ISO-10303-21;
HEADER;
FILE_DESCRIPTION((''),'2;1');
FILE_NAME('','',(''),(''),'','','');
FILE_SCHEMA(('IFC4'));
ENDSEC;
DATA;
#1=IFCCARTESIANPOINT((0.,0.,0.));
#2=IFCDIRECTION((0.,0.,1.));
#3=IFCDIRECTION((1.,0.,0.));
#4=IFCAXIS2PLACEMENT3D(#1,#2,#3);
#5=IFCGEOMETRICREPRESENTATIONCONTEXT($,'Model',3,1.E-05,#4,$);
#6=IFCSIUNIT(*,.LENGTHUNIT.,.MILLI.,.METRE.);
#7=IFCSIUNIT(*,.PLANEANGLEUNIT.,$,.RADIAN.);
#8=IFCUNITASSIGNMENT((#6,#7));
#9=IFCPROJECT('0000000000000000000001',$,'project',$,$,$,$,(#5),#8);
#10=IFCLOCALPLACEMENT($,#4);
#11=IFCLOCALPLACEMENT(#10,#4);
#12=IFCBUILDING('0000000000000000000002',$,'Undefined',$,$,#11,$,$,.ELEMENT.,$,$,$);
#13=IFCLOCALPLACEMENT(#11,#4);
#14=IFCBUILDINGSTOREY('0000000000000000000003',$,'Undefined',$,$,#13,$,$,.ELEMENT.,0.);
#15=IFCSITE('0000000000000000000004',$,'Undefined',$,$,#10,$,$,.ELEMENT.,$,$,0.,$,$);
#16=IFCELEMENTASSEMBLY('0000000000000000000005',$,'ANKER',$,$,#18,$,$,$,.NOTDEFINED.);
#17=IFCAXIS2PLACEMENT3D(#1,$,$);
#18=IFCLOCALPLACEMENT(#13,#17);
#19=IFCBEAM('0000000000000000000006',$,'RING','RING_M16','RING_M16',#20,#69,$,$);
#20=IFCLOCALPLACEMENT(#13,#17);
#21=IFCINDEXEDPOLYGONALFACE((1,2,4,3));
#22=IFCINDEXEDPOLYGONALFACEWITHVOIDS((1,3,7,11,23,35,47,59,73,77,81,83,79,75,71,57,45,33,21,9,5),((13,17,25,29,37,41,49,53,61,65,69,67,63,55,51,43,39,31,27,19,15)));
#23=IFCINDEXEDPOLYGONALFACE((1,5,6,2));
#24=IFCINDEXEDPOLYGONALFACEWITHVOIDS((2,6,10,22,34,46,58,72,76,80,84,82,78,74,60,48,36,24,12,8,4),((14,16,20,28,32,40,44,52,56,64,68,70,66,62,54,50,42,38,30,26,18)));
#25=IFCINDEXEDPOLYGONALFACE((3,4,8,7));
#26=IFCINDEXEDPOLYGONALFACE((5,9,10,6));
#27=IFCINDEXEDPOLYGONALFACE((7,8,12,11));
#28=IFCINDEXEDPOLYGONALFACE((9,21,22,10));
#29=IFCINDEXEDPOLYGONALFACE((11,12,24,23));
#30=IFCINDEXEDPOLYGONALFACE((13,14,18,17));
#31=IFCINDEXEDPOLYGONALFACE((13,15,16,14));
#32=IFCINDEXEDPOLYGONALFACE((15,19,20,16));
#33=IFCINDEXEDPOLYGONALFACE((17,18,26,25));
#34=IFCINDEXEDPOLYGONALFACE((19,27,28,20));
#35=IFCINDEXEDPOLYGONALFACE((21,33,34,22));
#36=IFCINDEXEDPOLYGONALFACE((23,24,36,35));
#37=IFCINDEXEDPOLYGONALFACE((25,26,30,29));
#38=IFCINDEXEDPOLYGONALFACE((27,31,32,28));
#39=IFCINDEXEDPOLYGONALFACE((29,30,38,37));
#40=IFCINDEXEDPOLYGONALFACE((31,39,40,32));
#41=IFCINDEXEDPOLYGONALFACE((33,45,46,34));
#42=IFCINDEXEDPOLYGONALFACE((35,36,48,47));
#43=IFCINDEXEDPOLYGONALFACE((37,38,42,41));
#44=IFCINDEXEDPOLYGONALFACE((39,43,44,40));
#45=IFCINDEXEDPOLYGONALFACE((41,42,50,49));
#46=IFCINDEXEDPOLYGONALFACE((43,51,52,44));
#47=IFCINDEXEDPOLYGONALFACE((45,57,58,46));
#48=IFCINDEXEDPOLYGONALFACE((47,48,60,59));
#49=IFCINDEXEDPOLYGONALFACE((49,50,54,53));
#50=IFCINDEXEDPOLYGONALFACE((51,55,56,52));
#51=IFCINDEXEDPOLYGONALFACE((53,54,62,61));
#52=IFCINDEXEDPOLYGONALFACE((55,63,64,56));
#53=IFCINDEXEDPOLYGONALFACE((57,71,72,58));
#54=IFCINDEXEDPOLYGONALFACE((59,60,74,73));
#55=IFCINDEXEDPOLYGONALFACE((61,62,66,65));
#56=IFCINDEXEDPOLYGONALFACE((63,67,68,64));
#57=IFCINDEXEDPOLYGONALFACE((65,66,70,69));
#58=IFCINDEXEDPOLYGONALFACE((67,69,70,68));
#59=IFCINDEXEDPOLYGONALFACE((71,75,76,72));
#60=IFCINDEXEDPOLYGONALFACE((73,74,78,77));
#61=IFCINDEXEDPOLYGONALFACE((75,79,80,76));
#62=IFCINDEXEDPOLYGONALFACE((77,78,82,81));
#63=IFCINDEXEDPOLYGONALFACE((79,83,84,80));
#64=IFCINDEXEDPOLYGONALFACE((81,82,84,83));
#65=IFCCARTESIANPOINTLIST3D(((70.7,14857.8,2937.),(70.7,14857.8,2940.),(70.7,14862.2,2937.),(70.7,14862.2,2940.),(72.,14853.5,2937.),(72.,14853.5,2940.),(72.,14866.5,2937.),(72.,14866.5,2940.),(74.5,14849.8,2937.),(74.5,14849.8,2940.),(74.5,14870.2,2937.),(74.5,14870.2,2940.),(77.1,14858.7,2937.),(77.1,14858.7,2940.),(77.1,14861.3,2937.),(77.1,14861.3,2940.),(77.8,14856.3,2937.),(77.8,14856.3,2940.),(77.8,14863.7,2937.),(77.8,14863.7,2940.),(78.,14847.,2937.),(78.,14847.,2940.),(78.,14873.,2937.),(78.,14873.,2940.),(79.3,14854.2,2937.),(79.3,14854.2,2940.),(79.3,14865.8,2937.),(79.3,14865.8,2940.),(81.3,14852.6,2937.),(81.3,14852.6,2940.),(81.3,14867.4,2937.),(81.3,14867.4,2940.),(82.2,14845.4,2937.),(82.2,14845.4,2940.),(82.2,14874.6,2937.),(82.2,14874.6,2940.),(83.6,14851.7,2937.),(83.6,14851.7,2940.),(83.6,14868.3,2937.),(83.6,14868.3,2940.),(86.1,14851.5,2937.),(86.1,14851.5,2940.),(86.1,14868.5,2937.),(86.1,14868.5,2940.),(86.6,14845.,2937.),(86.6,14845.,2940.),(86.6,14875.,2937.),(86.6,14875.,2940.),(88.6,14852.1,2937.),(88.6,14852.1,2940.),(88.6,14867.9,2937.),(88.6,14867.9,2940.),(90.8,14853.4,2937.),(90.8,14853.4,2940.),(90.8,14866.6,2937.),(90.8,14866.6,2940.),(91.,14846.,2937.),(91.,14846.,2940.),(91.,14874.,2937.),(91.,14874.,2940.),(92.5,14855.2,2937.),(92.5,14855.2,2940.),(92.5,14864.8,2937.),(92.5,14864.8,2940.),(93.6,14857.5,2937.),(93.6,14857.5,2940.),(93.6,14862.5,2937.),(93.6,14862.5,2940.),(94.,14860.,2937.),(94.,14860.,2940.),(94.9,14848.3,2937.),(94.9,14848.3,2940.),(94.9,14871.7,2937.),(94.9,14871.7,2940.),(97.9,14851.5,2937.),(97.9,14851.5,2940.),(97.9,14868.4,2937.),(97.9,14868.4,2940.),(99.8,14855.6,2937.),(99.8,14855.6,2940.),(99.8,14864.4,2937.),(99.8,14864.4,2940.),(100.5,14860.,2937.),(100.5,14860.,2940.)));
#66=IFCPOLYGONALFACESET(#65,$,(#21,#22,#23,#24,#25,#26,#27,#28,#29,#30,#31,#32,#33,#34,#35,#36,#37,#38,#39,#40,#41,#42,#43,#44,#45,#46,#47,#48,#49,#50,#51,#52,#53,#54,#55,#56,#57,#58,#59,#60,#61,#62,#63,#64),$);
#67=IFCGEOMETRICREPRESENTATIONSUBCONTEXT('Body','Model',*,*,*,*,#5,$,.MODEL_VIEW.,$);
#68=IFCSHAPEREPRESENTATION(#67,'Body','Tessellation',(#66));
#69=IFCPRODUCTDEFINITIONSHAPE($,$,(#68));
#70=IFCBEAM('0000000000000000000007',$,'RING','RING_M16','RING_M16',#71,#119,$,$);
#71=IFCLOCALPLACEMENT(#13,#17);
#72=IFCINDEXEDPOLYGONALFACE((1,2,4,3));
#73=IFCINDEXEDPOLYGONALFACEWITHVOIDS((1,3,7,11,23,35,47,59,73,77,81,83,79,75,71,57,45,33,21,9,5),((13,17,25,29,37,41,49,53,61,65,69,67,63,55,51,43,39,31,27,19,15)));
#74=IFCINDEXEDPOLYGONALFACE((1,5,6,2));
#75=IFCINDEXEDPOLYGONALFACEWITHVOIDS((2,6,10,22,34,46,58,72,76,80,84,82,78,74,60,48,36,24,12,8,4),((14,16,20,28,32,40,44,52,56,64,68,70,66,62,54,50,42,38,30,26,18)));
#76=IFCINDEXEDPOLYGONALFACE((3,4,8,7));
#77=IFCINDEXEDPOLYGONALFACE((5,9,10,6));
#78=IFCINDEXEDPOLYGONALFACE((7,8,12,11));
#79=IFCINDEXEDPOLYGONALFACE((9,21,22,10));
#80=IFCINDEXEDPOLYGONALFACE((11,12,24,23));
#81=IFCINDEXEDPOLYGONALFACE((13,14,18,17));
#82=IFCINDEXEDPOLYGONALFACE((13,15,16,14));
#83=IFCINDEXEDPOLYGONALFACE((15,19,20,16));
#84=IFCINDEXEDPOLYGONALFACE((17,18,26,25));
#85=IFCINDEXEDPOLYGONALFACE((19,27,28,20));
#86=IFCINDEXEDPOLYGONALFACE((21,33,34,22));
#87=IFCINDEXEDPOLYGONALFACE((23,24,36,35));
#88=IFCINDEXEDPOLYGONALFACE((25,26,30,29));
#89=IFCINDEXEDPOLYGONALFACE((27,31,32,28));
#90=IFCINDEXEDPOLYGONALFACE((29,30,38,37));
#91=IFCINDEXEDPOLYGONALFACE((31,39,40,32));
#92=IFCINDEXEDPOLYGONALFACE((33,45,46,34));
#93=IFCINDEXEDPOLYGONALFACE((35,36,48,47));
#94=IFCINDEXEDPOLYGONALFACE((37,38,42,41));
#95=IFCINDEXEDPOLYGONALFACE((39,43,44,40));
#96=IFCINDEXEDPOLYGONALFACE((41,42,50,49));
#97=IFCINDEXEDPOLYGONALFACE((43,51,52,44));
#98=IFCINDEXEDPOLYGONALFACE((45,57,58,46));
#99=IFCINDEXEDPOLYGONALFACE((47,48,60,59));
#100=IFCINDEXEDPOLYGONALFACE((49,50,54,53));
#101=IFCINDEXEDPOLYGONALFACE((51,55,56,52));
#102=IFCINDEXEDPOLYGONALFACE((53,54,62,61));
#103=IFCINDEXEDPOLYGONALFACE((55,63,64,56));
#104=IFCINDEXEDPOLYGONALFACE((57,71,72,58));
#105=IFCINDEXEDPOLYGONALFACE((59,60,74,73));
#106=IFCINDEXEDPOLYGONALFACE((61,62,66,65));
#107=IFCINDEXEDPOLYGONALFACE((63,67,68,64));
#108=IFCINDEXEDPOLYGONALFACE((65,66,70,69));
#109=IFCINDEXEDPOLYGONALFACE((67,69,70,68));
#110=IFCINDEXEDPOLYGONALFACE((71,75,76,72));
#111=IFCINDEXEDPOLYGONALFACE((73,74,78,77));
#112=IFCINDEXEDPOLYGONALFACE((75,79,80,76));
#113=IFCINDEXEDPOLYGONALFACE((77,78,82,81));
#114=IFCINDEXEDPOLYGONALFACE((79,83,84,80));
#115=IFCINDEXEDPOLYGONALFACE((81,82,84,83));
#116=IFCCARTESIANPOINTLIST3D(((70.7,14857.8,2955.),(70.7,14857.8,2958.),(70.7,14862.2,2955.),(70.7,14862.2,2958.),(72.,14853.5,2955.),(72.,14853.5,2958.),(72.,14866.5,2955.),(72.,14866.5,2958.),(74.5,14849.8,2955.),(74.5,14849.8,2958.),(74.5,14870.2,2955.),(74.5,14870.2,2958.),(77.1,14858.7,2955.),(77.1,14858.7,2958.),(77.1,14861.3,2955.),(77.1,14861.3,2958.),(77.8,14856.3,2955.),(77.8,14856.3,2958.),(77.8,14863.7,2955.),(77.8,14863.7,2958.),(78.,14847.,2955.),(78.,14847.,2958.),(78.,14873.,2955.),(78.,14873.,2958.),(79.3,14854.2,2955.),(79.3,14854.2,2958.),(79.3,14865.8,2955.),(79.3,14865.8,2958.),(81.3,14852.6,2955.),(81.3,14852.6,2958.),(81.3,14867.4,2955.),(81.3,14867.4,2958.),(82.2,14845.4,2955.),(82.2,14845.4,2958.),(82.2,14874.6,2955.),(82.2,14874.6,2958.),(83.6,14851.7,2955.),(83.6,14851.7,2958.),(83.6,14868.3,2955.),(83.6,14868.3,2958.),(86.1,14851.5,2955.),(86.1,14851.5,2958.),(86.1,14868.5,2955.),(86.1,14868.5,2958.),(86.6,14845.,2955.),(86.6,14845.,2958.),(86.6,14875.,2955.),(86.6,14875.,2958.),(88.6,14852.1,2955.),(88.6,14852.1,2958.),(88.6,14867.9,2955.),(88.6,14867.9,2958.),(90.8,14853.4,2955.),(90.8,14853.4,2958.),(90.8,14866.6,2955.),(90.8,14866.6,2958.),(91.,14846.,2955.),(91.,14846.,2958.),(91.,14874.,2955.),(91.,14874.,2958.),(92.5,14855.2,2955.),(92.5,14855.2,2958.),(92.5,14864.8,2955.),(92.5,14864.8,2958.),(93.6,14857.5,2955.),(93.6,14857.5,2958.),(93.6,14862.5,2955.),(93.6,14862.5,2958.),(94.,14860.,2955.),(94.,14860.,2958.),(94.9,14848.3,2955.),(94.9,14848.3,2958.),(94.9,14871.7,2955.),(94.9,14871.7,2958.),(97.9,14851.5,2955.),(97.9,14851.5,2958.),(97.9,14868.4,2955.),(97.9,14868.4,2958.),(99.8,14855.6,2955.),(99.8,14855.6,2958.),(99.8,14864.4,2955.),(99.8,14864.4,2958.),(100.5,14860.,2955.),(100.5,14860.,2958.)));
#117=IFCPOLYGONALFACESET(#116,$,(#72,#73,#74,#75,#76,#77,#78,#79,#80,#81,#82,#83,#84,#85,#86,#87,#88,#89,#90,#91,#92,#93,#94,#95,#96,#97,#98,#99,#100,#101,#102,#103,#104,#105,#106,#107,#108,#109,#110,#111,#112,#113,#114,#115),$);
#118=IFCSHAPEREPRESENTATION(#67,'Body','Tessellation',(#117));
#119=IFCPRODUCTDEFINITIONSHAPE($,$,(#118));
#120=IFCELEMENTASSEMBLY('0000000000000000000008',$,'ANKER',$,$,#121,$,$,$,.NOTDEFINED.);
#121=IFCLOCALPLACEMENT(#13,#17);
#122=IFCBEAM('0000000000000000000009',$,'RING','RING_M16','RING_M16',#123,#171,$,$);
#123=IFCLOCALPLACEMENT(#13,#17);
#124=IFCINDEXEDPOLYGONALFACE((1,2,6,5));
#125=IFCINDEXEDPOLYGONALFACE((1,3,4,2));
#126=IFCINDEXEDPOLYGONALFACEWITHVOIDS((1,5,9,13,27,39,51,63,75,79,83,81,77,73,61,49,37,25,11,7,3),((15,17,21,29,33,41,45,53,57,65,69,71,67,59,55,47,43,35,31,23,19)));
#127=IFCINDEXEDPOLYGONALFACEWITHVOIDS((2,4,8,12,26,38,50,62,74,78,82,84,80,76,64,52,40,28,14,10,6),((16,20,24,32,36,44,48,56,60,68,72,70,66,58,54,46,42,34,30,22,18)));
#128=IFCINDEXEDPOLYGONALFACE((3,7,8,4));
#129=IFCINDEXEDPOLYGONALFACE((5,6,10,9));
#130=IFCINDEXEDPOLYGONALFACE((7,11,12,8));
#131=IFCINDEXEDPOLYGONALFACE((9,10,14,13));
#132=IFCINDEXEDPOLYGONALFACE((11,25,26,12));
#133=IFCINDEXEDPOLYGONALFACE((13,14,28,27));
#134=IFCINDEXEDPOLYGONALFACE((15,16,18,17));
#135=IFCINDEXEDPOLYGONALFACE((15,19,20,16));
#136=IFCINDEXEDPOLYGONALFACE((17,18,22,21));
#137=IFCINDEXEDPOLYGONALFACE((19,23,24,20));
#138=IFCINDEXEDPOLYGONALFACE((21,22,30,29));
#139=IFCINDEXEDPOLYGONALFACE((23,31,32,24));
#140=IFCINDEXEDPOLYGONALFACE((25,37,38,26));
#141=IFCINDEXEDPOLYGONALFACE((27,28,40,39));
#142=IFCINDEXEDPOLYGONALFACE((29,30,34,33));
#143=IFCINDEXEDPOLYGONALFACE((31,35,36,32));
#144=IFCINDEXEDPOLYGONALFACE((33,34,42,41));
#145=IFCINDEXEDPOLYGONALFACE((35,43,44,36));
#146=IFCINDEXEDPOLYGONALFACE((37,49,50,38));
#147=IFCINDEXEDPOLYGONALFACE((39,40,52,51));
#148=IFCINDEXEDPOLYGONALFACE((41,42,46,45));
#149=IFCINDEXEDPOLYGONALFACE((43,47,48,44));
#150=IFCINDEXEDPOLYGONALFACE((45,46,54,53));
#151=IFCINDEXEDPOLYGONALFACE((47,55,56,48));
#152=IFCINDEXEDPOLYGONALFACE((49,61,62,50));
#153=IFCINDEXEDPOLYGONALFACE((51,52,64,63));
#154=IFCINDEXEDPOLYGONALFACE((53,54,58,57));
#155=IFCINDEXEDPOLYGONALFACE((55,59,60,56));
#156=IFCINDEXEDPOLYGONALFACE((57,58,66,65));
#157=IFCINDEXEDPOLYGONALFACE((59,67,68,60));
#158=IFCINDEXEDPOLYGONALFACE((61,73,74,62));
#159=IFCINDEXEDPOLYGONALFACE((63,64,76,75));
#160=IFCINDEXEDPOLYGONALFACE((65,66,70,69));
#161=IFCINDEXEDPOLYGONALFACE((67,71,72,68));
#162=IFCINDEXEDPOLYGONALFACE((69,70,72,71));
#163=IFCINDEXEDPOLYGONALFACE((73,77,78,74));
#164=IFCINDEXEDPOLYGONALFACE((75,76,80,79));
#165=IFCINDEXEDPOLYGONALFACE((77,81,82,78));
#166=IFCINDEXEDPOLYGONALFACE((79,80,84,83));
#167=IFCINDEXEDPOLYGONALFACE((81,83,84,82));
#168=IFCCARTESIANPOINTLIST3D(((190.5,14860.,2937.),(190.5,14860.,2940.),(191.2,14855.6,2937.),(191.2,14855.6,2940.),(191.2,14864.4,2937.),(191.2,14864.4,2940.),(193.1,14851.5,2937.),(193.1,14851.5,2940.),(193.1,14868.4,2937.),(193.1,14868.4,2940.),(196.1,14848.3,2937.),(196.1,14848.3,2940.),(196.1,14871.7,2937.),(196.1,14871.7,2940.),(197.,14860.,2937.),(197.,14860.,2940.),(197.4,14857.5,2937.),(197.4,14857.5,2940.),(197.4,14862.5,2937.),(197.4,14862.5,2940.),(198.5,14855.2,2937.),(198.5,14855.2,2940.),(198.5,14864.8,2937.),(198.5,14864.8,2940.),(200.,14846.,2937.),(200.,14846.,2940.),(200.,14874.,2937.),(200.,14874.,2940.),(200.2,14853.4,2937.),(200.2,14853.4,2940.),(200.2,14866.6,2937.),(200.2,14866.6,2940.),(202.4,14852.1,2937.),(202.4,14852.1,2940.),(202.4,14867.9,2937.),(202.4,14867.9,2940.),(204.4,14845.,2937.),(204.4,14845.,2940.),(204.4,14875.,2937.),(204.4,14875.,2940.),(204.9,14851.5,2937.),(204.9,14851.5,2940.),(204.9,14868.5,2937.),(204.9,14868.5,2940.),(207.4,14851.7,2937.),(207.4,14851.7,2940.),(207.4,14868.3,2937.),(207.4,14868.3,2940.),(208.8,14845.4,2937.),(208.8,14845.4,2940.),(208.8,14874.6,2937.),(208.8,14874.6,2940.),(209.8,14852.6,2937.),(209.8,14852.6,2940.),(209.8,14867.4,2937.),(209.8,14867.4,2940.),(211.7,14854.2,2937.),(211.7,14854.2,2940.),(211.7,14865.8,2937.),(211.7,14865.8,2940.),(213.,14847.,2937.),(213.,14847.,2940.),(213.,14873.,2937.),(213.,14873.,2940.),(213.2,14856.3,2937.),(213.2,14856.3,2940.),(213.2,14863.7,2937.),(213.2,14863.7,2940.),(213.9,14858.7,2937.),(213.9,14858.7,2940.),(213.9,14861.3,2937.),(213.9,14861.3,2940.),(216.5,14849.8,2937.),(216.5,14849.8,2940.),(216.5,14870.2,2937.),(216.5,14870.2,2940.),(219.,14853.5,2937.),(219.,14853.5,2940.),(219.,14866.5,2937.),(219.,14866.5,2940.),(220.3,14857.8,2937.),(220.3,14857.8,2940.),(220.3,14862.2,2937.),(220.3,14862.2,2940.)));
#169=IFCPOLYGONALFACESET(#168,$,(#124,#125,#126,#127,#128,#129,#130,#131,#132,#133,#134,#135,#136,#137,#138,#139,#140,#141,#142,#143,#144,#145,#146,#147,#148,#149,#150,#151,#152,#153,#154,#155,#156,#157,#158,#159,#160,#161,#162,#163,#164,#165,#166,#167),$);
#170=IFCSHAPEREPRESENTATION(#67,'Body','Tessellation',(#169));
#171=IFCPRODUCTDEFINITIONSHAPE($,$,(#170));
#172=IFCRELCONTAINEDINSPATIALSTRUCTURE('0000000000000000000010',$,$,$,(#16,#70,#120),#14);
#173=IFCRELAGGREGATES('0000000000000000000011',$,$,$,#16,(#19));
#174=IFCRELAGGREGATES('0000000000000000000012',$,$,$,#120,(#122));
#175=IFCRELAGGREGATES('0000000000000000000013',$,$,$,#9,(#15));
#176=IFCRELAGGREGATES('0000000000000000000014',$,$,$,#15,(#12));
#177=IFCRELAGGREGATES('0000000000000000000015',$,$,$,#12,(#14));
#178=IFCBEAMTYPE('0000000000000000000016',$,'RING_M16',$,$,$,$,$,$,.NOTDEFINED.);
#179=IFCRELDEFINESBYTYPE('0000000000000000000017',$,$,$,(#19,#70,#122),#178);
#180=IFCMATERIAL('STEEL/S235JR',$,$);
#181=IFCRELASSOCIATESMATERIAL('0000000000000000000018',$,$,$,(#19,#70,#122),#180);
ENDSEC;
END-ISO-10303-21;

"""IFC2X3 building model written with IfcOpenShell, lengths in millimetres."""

from ifc_helpers import new_model, si_unit, frame, origin_with_axes, origin_2d_with_axis, place, context, subcontext, project, spatial, hollow_circle, extrude, material, type_object, element, aggregate, save


model = new_model("IFC2X3")

# Units and contexts
model_context = context("Model", 3, precision=1e-05, world=origin_with_axes())
body_context = subcontext(model_context, "Body", "Model", "MODEL_VIEW")
ifc_project = project(units=[si_unit("LENGTHUNIT", "METRE", prefix="MILLI"), si_unit("PLANEANGLEUNIT", "RADIAN")], contexts=[model_context])

# Site, building, storey
site_placement = place(None, origin_with_axes())
site = spatial("IfcSite", under=ifc_project, at=site_placement, Name="Undefined", CompositionType="ELEMENT", RefElevation=0.0)
building_placement = place(site_placement, origin_with_axes())
building = spatial("IfcBuilding", under=site, at=building_placement, Name="Undefined", CompositionType="ELEMENT")
storey_placement = place(building_placement, origin_with_axes())
storey = spatial("IfcBuildingStorey", under=building, at=storey_placement, Name="Undefined", CompositionType="ELEMENT", Elevation=0.0)

# Shared definitions
ifc_material = material(Name="STEEL/S235JR")

# Shared definitions
beam_type_1 = type_object("IfcBeamType", Name="RING_M16", PredefinedType="NOTDEFINED")

# Element assembly, beam
assembly_1_placement = place(storey_placement, frame((85.5, 14860.0, 2995.0), z_axis=(0.0, 1.0, 0.0), x_axis=(0.0, 0.0, -1.0)))
assembly_1 = element("IfcElementAssembly", 1, at=assembly_1_placement, inside=storey, Name="ANKER", PredefinedType="NOTDEFINED")
beam_1_placement = place(storey_placement, frame((85.5, 14860.0, 2940.0), z_axis=(0.0, 1.0, 0.0), x_axis=(0.0, 0.0, -1.0)))
beam_1 = element("IfcBeam", 2, at=beam_1_placement, type_object=beam_type_1, material=ifc_material, Name="RING", Description="RING_M16", ObjectType="RING_M16", context=body_context, shape_type="SweptSolid", body=[
    extrude(hollow_circle(Radius=15.0, WallThickness=6.5, at=origin_2d_with_axis()), frame((3.0, 0.0, 0.0), z_axis=(-1.0, 0.0, 0.0), x_axis=(0.0, -1.0, 0.0)), (0.0, 0.0, 1.0), 3.0),
])
aggregate(assembly_1, [beam_1])

# Beam
beam_2_placement = place(storey_placement, frame((85.5, 14860.0, 2958.0), z_axis=(0.0, 1.0, 0.0), x_axis=(0.0, 0.0, -1.0)))
element("IfcBeam", 3, at=beam_2_placement, inside=storey, type_object=beam_type_1, material=ifc_material, Name="RING", Description="RING_M16", ObjectType="RING_M16", context=body_context, shape_type="SweptSolid", body=[
    extrude(hollow_circle(Radius=15.0, WallThickness=6.5, at=origin_2d_with_axis()), frame((3.0, 0.0, 0.0), z_axis=(-1.0, 0.0, 0.0), x_axis=(0.0, -1.0, 0.0)), (0.0, 0.0, 1.0), 3.0),
])

# Element assembly, beam
assembly_2_placement = place(storey_placement, frame((205.5, 14860.0, 2995.0), z_axis=(0.0, -1.0, 0.0), x_axis=(0.0, 0.0, -1.0)))
assembly_2 = element("IfcElementAssembly", 4, at=assembly_2_placement, inside=storey, Name="ANKER", PredefinedType="NOTDEFINED")
beam_3_placement = place(storey_placement, frame((205.5, 14860.0, 2940.0), z_axis=(0.0, -1.0, 0.0), x_axis=(0.0, 0.0, -1.0)))
beam_3 = element("IfcBeam", 5, at=beam_3_placement, type_object=beam_type_1, material=ifc_material, Name="RING", Description="RING_M16", ObjectType="RING_M16", context=body_context, shape_type="SweptSolid", body=[
    extrude(hollow_circle(Radius=15.0, WallThickness=6.5, at=origin_2d_with_axis()), frame((3.0, 0.0, 0.0), z_axis=(-1.0, 0.0, 0.0), x_axis=(0.0, -1.0, 0.0)), (0.0, 0.0, 1.0), 3.0),
])
aggregate(assembly_2, [beam_3])

save(model, "model.ifc")
